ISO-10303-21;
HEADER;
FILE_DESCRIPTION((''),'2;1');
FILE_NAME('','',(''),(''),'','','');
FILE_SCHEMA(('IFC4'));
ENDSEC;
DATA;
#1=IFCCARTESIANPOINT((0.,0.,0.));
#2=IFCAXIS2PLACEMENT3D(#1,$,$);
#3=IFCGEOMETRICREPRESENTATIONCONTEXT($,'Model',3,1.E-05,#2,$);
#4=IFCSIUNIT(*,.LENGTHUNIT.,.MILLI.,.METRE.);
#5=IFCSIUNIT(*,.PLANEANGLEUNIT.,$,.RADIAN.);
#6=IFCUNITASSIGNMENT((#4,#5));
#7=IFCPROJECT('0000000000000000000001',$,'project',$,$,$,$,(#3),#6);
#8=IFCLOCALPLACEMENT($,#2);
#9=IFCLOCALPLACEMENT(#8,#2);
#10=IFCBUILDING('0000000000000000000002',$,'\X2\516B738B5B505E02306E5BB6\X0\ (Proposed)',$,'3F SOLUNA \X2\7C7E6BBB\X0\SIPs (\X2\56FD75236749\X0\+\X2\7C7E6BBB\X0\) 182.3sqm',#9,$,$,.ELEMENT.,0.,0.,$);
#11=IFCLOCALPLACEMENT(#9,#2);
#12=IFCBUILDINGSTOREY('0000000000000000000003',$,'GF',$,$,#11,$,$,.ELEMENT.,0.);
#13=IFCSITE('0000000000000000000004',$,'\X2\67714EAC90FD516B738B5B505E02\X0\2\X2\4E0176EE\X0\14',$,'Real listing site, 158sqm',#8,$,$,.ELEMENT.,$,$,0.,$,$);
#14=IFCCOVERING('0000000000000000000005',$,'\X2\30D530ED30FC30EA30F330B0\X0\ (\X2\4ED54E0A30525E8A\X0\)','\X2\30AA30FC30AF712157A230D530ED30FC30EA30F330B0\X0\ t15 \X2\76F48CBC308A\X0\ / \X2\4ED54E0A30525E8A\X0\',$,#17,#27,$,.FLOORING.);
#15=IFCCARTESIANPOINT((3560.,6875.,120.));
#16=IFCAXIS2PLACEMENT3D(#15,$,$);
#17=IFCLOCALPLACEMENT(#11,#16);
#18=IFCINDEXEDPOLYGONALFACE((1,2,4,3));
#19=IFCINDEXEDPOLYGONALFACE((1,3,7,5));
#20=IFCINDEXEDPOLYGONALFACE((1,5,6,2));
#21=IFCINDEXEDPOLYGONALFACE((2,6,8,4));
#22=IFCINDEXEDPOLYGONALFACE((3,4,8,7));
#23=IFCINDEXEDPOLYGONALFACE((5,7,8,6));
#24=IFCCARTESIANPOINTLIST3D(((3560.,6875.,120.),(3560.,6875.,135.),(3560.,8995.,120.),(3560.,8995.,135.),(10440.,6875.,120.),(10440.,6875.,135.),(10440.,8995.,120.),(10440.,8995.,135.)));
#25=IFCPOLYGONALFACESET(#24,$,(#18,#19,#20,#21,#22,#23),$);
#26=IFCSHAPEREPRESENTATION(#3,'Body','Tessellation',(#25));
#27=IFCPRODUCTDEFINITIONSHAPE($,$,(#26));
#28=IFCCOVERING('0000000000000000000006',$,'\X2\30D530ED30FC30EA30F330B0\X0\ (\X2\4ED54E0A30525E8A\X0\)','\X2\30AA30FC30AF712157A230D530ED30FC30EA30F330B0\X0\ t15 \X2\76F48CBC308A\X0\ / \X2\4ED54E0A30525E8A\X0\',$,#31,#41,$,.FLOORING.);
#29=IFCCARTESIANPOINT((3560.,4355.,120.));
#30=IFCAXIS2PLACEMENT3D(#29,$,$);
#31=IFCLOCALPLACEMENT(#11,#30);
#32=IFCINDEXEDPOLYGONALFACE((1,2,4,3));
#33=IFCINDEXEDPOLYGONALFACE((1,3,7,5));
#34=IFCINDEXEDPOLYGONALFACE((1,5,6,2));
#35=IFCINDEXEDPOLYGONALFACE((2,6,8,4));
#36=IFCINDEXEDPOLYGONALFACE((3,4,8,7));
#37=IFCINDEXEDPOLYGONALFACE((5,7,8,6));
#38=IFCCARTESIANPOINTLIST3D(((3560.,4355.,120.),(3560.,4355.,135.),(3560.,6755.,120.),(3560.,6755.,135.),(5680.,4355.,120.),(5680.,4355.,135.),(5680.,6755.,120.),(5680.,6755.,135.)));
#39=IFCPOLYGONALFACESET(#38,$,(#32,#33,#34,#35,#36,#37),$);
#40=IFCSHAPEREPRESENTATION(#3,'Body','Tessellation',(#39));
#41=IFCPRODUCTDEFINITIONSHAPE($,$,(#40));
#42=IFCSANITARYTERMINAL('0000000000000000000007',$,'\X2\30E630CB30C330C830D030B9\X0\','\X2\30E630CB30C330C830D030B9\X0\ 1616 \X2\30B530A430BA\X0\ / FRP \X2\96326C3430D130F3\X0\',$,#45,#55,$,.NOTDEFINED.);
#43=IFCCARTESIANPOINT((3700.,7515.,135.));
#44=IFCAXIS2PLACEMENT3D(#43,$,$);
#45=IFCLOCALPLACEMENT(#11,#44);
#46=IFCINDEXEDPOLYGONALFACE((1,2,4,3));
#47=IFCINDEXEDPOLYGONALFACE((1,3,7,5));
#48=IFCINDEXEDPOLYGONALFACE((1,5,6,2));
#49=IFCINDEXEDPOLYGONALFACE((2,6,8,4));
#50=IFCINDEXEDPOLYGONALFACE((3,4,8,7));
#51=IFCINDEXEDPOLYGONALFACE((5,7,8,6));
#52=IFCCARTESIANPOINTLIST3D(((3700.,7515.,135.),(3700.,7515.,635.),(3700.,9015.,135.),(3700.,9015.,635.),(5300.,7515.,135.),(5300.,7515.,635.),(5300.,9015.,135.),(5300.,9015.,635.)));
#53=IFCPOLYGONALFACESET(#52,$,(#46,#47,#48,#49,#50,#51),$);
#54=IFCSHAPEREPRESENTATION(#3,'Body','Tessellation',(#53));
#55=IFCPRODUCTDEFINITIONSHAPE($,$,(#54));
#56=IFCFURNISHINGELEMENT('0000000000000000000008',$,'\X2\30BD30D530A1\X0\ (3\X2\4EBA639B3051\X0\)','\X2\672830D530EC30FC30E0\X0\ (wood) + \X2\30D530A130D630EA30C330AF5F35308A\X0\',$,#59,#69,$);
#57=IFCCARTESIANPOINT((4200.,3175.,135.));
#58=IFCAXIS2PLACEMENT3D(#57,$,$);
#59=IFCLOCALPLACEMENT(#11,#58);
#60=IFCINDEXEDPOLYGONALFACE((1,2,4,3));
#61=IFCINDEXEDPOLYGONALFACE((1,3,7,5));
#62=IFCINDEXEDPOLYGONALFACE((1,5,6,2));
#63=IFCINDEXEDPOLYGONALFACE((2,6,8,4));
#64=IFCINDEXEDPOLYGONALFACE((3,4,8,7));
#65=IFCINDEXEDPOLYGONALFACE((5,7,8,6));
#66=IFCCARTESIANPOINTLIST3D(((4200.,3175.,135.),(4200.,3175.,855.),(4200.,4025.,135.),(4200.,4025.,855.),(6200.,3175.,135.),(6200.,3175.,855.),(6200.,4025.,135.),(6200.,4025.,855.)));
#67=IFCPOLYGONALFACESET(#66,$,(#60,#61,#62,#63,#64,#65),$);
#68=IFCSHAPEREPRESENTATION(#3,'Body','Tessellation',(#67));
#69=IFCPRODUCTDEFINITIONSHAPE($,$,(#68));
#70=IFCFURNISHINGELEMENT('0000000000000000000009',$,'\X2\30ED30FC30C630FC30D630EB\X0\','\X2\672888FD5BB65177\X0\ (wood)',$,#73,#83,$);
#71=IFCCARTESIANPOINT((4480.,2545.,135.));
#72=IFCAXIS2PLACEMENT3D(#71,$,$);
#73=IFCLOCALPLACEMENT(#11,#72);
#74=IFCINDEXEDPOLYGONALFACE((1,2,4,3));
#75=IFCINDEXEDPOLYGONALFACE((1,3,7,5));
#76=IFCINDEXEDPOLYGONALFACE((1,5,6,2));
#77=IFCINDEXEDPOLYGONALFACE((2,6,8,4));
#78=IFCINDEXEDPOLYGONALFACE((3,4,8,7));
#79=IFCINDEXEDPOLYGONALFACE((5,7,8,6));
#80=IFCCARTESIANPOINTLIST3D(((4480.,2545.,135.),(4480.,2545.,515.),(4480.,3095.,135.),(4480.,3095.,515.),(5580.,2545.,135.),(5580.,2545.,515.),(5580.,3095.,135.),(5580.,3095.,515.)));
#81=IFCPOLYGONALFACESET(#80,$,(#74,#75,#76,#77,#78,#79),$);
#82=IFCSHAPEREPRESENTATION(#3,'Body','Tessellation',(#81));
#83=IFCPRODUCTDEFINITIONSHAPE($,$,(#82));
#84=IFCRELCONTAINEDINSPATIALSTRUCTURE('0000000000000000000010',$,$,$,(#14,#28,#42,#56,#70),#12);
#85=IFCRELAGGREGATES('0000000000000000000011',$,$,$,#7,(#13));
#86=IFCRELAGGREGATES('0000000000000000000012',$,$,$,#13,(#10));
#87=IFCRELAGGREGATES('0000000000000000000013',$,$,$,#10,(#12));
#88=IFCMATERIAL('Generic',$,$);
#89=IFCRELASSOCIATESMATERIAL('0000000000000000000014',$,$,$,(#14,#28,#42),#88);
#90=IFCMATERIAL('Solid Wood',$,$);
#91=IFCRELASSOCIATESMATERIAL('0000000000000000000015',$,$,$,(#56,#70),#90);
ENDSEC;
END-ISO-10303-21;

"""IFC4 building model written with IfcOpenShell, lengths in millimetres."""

from ifc_helpers import new_model, si_unit, frame, frame_2d, origin, place, context, project, spatial, rectangle, extrude, material, element, save


model = new_model("IFC4")

# Units and contexts
model_context = context("Model", 3, precision=1e-05, world=origin())
ifc_project = project(units=[si_unit("LENGTHUNIT", "METRE", prefix="MILLI"), si_unit("PLANEANGLEUNIT", "RADIAN")], contexts=[model_context])

# Site, building, storey
site_placement = place(None, origin())
site = spatial("IfcSite", under=ifc_project, at=site_placement, Name="東京都八王子市2丁目14", ObjectType="Real listing site, 158sqm", CompositionType="ELEMENT", RefElevation=0.0)
building_placement = place(site_placement, origin())
building = spatial("IfcBuilding", under=site, at=building_placement, Name="八王子市の家 (Proposed)", ObjectType="3F SOLUNA 籾殻SIPs (国産杉+籾殻) 182.3sqm", CompositionType="ELEMENT", ElevationOfRefHeight=0.0, ElevationOfTerrain=0.0)
storey_placement = place(building_placement, origin())
storey = spatial("IfcBuildingStorey", under=building, at=storey_placement, Name="GF", CompositionType="ELEMENT", Elevation=0.0)

# Shared definitions
ifc_material_1 = material(Name="Solid Wood")

# Coverings
ifc_material_2 = material(Name="Generic")
covering_1_placement = place(storey_placement, frame((3560.0, 6875.0, 120.0)))
element("IfcCovering", 1, at=covering_1_placement, inside=storey, material=ifc_material_2, Name="フローリング (仕上げ床)", Description="オーク無垢フローリング t15 直貼り / 仕上げ床", PredefinedType="FLOORING", context=model_context, shape_type="SweptSolid", body=[
    extrude(rectangle(XDim=6880.0, YDim=2120.0, at=frame_2d((3440.0, 1060.0))), frame((3560.0, 6875.0, 120.0)), (0.0, 0.0, 1.0), 15.0),
])
covering_2_placement = place(storey_placement, frame((3560.0, 4355.0, 120.0)))
element("IfcCovering", 2, at=covering_2_placement, inside=storey, material=ifc_material_2, Name="フローリング (仕上げ床)", Description="オーク無垢フローリング t15 直貼り / 仕上げ床", PredefinedType="FLOORING", context=model_context, shape_type="SweptSolid", body=[
    extrude(rectangle(XDim=2120.0, YDim=2400.0, at=frame_2d((1060.0, 1200.0))), frame((3560.0, 4355.0, 120.0)), (0.0, 0.0, 1.0), 15.0),
])

# Sanitary terminal
sanitary_terminal_placement = place(storey_placement, frame((3700.0, 7515.0, 135.0)))
element("IfcSanitaryTerminal", 3, at=sanitary_terminal_placement, inside=storey, material=ifc_material_2, Name="ユニットバス", Description="ユニットバス 1616 サイズ / FRP 防水パン", PredefinedType="NOTDEFINED", context=model_context, shape_type="SweptSolid", body=[
    extrude(rectangle(XDim=1600.0, YDim=1500.0, at=frame_2d((800.0, 750.0))), frame((3700.0, 7515.0, 135.0)), (0.0, 0.0, 1.0), 500.0),
])

# Furnishing elements
furnishing_1_placement = place(storey_placement, frame((4200.0, 3175.0, 135.0)))
element("IfcFurnishingElement", 4, at=furnishing_1_placement, inside=storey, material=ifc_material_1, Name="ソファ (3人掛け)", Description="木フレーム (wood) + ファブリック張り", context=model_context, shape_type="SweptSolid", body=[
    extrude(rectangle(XDim=2000.0, YDim=850.0, at=frame_2d((1000.0, 425.0))), frame((4200.0, 3175.0, 135.0)), (0.0, 0.0, 1.0), 720.0),
])
furnishing_2_placement = place(storey_placement, frame((4480.0, 2545.0, 135.0)))
element("IfcFurnishingElement", 5, at=furnishing_2_placement, inside=storey, material=ifc_material_1, Name="ローテーブル", Description="木製家具 (wood)", context=model_context, shape_type="SweptSolid", body=[
    extrude(rectangle(XDim=1100.0, YDim=550.0, at=frame_2d((550.0, 275.0))), frame((4480.0, 2545.0, 135.0)), (0.0, 0.0, 1.0), 380.0),
])

save(model, "model.ifc")
